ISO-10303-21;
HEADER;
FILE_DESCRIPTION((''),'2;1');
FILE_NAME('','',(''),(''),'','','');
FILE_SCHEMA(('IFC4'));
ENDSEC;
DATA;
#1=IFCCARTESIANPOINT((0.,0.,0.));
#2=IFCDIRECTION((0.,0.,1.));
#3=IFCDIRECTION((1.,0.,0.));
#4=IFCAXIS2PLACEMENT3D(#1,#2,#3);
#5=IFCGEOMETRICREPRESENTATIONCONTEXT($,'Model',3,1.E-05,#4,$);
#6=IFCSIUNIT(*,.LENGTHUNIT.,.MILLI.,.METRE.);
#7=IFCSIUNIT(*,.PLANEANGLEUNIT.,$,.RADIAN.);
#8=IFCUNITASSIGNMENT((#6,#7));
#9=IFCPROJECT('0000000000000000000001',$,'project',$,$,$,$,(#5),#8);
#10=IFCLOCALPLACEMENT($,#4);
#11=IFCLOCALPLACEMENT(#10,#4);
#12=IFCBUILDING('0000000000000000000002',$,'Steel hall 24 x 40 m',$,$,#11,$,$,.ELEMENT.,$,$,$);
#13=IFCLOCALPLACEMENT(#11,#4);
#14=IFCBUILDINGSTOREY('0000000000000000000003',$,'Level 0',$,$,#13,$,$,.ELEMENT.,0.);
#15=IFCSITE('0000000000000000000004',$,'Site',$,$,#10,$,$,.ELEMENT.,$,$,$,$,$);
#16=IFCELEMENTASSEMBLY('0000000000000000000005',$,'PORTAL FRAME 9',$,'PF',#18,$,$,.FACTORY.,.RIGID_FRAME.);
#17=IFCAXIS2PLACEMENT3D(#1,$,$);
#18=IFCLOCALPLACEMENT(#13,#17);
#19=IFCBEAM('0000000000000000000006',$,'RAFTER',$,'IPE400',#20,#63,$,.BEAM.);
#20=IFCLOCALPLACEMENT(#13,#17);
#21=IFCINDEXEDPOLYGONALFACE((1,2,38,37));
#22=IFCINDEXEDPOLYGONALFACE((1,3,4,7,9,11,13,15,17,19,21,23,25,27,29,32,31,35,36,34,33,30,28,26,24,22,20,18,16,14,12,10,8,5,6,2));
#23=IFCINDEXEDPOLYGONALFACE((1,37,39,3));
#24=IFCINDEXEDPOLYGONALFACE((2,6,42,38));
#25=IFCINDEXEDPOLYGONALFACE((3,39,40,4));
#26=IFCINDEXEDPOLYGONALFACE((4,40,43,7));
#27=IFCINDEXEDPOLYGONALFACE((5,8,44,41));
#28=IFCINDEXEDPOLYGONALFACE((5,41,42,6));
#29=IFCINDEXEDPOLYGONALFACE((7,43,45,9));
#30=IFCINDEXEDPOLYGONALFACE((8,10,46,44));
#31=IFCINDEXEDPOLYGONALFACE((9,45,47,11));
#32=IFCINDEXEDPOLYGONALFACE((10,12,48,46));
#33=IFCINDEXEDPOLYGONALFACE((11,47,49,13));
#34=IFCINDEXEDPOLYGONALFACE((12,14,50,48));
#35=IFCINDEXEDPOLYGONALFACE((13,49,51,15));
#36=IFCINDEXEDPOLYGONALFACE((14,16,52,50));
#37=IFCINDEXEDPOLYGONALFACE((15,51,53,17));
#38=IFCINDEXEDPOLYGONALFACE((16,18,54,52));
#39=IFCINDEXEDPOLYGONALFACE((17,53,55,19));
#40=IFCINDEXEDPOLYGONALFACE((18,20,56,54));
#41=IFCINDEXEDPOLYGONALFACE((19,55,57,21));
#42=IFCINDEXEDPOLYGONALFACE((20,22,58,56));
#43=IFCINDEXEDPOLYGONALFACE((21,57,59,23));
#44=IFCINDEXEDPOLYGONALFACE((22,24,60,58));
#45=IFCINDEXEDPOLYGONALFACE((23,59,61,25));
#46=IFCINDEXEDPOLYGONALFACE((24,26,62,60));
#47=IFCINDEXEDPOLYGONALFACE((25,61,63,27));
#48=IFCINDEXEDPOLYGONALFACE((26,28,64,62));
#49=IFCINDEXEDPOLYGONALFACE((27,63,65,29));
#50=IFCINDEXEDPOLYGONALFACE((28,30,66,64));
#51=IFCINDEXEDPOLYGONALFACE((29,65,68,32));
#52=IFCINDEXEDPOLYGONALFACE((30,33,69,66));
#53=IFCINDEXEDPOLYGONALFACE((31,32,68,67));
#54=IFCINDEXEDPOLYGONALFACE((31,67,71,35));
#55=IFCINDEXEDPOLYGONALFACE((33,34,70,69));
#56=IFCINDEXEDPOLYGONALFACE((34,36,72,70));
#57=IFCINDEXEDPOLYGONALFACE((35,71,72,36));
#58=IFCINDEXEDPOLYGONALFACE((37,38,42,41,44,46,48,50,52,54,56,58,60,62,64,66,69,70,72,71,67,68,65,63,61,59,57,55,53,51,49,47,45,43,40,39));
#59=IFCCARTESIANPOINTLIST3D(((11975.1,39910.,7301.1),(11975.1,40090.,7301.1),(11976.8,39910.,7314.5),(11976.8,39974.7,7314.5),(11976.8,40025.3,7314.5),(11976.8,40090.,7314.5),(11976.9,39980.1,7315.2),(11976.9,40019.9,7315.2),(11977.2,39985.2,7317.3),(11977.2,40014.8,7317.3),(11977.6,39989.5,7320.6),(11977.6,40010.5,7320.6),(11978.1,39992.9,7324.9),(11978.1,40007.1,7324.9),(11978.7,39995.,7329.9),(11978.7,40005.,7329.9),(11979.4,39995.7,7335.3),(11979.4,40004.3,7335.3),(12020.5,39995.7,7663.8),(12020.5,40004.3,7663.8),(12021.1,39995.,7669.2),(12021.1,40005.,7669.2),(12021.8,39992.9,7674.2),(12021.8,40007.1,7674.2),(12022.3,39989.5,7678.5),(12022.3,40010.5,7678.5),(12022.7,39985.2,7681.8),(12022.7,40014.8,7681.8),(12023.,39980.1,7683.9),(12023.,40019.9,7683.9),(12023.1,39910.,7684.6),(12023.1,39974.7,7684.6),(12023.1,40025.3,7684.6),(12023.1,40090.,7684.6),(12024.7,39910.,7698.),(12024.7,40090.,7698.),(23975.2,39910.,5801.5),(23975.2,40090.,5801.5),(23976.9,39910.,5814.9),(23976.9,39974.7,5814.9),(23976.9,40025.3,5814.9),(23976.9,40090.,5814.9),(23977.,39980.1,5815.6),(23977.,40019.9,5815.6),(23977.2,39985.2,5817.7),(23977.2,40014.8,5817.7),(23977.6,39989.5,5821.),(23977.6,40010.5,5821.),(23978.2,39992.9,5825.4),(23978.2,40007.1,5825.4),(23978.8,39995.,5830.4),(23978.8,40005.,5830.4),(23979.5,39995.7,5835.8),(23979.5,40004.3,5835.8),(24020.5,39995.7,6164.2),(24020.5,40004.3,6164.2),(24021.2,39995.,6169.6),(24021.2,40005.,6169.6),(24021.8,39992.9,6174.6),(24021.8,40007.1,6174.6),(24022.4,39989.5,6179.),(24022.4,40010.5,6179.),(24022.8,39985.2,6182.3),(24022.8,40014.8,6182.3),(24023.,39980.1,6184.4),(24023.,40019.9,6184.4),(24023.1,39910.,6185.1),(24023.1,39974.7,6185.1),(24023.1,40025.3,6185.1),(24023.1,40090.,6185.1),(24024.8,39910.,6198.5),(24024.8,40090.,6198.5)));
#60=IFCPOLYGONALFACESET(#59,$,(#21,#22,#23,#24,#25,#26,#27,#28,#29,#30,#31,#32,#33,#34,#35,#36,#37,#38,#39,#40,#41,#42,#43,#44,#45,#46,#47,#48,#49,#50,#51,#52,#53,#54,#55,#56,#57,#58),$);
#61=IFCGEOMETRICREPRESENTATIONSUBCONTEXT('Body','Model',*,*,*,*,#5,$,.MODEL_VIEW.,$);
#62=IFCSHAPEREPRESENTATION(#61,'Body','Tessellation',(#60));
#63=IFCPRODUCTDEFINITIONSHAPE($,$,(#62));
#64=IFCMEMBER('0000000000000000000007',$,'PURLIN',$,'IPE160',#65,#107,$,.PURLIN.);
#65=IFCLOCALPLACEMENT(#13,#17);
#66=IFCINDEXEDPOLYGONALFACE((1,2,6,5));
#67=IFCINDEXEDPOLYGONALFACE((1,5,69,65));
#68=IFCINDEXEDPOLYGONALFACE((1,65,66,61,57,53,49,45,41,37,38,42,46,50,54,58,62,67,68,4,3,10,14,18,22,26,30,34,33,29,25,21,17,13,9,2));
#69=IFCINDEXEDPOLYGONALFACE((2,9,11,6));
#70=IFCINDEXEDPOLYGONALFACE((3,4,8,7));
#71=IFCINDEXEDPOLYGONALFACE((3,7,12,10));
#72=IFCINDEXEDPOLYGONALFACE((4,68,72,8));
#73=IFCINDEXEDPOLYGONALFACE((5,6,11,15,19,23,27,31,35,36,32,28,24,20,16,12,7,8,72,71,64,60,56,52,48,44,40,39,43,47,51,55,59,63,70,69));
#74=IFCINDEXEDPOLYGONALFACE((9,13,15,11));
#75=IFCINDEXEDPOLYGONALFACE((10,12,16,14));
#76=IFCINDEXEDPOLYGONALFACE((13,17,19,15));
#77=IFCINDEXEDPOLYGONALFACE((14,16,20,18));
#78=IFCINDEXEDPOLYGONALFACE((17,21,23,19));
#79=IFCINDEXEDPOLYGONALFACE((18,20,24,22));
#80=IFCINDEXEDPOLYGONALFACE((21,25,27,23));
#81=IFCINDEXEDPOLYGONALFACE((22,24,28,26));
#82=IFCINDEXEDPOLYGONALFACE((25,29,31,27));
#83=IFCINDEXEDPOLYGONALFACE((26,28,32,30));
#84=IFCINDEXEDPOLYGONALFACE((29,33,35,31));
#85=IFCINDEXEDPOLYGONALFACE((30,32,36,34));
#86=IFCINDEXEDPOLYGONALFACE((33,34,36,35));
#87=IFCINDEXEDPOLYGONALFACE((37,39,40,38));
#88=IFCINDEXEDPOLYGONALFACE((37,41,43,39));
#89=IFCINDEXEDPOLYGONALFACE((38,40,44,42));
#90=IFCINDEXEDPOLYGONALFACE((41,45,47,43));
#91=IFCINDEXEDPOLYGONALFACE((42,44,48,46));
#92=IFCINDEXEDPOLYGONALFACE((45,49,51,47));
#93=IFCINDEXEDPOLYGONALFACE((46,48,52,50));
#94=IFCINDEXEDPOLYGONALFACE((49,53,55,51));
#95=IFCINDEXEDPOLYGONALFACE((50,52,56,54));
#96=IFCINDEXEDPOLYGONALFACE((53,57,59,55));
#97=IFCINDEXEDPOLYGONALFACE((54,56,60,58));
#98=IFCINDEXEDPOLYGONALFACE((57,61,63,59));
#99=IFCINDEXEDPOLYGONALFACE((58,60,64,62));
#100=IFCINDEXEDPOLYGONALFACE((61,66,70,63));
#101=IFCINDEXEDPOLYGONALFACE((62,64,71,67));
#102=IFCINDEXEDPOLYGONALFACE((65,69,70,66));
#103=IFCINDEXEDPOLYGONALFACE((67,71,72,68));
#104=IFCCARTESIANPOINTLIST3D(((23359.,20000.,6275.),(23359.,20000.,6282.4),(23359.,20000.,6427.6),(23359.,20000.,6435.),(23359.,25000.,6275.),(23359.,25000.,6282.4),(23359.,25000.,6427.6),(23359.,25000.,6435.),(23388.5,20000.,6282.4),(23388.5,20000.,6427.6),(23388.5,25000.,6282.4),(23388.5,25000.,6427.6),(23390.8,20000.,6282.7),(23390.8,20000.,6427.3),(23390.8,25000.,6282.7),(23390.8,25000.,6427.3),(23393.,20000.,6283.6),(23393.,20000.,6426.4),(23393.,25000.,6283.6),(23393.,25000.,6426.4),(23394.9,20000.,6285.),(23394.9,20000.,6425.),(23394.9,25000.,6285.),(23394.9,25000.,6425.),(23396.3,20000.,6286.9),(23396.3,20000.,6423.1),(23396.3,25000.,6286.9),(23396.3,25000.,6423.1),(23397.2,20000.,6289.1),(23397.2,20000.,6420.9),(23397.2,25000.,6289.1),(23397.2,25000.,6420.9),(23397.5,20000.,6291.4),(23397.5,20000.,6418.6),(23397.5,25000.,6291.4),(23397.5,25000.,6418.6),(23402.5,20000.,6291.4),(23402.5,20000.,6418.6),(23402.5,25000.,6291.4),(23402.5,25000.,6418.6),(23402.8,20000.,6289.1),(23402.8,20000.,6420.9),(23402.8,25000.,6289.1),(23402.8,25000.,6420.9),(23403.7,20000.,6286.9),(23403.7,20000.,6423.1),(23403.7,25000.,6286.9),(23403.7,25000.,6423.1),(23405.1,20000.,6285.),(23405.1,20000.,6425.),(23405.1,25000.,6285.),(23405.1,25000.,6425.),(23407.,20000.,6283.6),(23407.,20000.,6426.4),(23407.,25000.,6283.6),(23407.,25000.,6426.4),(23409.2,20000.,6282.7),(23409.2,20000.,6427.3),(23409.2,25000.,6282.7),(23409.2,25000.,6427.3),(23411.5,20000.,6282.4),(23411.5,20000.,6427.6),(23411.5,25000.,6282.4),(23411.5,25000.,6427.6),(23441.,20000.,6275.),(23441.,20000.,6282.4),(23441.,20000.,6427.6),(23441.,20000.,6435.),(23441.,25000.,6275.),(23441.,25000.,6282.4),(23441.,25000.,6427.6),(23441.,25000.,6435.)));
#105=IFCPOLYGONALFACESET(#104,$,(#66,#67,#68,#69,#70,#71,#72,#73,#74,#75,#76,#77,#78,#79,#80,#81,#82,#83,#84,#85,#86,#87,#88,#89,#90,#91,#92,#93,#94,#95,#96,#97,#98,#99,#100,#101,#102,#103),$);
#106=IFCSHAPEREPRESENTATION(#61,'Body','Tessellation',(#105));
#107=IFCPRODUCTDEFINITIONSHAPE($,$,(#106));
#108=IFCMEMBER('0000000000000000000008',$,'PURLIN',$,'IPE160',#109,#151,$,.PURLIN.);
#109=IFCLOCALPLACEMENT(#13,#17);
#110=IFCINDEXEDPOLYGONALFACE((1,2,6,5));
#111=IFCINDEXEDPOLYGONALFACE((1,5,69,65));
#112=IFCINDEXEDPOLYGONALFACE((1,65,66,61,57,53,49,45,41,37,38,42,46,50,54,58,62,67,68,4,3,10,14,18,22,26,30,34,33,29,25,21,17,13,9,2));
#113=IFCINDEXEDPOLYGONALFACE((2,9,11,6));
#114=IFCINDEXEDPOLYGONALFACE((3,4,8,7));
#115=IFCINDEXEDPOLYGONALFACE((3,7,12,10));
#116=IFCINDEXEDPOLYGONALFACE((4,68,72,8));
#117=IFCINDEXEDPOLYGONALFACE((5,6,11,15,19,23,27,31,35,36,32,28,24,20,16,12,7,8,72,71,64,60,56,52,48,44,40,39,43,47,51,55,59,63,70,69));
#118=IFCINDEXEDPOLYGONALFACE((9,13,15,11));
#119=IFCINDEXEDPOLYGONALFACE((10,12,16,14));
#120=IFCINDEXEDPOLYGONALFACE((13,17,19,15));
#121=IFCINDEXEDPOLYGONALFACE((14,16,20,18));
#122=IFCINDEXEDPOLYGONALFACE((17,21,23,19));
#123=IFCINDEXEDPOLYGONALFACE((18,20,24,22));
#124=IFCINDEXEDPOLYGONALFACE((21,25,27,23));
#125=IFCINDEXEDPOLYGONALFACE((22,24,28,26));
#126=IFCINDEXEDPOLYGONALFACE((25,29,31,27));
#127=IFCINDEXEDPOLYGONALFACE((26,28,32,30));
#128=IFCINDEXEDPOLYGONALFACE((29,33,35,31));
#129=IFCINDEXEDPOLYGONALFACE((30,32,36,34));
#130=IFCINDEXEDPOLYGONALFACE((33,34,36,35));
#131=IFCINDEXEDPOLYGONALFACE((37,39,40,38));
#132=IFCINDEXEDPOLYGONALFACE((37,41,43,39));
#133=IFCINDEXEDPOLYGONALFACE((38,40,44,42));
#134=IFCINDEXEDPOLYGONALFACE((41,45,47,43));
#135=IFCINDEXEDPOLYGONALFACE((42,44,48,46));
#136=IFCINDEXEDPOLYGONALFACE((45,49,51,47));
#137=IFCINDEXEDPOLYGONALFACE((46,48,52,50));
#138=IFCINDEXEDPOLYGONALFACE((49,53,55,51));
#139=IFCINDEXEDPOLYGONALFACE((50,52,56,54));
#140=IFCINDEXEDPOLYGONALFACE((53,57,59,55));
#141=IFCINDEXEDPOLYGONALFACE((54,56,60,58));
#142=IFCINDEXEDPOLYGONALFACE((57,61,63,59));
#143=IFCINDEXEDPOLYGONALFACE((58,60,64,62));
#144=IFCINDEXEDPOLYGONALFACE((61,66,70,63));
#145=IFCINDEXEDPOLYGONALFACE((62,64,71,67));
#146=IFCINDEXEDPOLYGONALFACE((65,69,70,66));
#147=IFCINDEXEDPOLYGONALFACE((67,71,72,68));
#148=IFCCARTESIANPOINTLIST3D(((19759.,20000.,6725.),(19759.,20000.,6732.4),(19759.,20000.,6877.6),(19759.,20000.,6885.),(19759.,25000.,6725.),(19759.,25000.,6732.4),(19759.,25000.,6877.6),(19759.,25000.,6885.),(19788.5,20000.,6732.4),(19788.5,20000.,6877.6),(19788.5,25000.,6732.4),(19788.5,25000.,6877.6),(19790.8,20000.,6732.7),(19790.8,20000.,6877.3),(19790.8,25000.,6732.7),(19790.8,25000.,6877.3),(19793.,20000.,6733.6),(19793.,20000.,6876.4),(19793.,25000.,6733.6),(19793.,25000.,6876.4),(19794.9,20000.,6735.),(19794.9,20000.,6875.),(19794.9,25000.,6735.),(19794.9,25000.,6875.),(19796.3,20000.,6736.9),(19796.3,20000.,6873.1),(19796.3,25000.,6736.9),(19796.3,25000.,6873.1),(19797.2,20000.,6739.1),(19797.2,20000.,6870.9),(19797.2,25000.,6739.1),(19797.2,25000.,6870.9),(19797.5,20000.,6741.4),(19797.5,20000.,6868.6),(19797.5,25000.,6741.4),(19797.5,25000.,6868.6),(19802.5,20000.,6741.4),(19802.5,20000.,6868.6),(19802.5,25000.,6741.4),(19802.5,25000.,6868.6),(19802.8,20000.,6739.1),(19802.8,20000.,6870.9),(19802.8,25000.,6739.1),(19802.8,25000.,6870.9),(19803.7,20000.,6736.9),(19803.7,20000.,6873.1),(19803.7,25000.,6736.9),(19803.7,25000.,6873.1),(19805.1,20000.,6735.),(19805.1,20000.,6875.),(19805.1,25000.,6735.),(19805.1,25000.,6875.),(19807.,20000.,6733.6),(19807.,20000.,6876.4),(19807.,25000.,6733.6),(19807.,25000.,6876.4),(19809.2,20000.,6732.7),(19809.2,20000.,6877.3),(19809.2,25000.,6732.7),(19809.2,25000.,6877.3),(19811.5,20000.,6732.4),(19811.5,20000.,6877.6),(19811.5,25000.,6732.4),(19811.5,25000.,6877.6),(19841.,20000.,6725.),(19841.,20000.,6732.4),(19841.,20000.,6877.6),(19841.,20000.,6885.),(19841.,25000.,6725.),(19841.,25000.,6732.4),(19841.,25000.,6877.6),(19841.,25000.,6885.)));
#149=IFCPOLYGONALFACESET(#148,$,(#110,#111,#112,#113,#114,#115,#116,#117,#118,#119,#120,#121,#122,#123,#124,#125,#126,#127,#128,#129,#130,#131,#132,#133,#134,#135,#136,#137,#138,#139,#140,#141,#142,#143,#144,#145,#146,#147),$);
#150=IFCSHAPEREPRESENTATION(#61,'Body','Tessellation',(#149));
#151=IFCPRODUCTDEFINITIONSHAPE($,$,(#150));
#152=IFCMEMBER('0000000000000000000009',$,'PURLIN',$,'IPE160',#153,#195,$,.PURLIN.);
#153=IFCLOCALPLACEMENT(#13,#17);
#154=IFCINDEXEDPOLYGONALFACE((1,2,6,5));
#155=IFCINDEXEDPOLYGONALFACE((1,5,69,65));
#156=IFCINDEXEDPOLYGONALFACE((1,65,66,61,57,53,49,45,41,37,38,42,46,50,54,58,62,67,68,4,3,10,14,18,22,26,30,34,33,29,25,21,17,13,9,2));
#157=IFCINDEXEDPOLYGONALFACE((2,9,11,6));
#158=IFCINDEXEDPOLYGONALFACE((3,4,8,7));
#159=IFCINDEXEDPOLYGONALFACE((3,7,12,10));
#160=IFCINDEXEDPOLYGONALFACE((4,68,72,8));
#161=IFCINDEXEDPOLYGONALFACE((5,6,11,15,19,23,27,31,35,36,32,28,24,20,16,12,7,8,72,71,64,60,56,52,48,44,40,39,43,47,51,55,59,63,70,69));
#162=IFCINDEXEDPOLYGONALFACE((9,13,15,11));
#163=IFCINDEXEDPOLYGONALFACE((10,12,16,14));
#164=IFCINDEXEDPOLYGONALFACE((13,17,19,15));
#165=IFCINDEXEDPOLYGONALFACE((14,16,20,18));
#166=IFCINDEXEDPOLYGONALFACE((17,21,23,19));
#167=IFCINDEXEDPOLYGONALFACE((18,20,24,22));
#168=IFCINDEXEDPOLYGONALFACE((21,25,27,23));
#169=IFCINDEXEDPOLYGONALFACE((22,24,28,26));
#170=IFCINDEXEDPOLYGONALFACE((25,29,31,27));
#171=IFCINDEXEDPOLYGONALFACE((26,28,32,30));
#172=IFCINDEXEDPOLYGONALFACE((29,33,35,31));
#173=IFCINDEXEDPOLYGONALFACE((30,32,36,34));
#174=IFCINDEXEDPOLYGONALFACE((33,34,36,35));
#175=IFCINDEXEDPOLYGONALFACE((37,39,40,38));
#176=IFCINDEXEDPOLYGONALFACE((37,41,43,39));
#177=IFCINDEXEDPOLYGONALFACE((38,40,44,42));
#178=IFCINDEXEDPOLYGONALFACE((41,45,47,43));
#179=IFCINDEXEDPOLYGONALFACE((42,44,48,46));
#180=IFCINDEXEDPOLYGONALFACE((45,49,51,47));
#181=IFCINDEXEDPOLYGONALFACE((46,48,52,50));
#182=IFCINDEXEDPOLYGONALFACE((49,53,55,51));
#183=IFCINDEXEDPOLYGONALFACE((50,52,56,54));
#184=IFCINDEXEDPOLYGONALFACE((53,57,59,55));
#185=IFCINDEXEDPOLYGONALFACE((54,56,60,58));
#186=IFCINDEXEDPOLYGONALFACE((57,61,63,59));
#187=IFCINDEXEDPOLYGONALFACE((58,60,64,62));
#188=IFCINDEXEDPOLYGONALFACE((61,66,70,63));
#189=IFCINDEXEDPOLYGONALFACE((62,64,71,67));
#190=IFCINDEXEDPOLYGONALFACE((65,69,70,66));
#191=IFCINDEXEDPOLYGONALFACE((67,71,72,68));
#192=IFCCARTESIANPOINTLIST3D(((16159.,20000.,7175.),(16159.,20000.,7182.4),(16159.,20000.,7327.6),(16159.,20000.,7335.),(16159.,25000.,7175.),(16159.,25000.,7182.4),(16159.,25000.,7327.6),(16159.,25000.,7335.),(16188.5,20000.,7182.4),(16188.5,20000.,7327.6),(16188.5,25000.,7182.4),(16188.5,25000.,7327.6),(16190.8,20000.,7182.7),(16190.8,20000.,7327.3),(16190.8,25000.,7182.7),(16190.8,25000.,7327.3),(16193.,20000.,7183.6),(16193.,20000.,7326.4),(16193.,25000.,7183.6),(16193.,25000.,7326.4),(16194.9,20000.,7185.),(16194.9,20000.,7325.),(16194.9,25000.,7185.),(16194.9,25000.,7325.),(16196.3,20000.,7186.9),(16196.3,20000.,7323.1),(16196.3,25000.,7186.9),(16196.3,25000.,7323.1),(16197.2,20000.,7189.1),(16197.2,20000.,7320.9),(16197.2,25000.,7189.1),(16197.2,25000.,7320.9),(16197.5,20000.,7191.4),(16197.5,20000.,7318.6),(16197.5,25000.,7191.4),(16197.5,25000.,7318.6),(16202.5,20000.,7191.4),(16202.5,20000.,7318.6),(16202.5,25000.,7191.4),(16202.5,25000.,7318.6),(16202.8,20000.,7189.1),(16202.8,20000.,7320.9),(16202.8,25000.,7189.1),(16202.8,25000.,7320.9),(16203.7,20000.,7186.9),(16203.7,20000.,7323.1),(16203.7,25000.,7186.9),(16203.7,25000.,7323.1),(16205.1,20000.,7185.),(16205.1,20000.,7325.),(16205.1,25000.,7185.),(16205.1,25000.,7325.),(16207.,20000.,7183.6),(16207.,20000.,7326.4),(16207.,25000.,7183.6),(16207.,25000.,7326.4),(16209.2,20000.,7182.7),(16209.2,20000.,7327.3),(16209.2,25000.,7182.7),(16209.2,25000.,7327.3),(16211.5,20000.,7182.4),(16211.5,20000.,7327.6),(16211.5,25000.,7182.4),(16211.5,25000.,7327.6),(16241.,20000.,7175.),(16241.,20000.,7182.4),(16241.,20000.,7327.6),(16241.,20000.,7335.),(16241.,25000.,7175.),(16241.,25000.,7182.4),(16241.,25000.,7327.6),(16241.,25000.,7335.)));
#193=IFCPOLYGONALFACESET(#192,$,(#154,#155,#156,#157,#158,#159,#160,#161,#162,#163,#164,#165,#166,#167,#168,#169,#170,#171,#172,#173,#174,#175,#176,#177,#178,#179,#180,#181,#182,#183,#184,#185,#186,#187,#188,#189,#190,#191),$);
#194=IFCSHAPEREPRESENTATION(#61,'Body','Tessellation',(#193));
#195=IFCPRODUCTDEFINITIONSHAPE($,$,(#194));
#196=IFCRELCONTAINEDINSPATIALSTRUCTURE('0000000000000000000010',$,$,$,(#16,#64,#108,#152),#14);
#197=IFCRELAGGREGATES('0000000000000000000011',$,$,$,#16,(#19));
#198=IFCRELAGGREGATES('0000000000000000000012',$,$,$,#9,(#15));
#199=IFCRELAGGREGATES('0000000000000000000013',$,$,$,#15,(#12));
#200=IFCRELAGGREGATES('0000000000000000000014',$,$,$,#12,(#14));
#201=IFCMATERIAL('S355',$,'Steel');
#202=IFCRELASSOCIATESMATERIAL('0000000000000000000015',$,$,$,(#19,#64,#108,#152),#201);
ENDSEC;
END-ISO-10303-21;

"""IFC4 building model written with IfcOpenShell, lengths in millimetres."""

from ifc_helpers import new_model, si_unit, frame, origin_with_axes, place, context, subcontext, project, spatial, i_section, extrude, material, element, aggregate, save


model = new_model("IFC4")

# Units and contexts
model_context = context("Model", 3, precision=1e-05, world=origin_with_axes())
body_context = subcontext(model_context, "Body", "Model", "MODEL_VIEW")
ifc_project = project(units=[si_unit("LENGTHUNIT", "METRE", prefix="MILLI"), si_unit("PLANEANGLEUNIT", "RADIAN")], contexts=[model_context])

# Site, building, storey
site_placement = place(None, origin_with_axes())
site = spatial("IfcSite", under=ifc_project, at=site_placement, Name="Site", CompositionType="ELEMENT")
building_placement = place(site_placement, origin_with_axes())
building = spatial("IfcBuilding", under=site, at=building_placement, Name="Steel hall 24 x 40 m", CompositionType="ELEMENT")
storey_placement = place(building_placement, origin_with_axes())
storey = spatial("IfcBuildingStorey", under=building, at=storey_placement, Name="Level 0", CompositionType="ELEMENT", Elevation=0.0)

# Element assembly
ifc_material = material(Name="S355", Category="Steel")
assembly_1_placement = place(storey_placement, frame((0.0, 40000.0, 0.0), z_axis=(0.0, 0.0, 1.0), x_axis=(1.0, 0.0, 0.0)))
assembly_1 = element("IfcElementAssembly", 1, at=assembly_1_placement, inside=storey, Name="PORTAL FRAME 9", ObjectType="PF", AssemblyPlace="FACTORY", PredefinedType="RIGID_FRAME")

# Beam
beam_1_placement = place(storey_placement, frame((24000.0, 40000.0, 6000.0), z_axis=(-0.9923, 0.0, 0.124), x_axis=(0.0, 1.0, 0.0)))
beam_1 = element("IfcBeam", 2, at=beam_1_placement, material=ifc_material, Name="RAFTER", ObjectType="IPE400", PredefinedType="BEAM", context=body_context, shape_type="SweptSolid", body=[
    extrude(i_section(OverallWidth=180.0, OverallDepth=400.0, WebThickness=8.6, FlangeThickness=13.5, FilletRadius=21.0), origin_with_axes(), (0.0, 0.0, 1.0), 12093.4),
])

# Members
for number, where, z_axis, x_axis, name in (
    (3, (23400.0, 20000.0, 6355.0), (0.0, 1.0, 0.0), (1.0, 0.0, 0.0), "PURLIN"),
    (4, (19800.0, 20000.0, 6805.0), (0.0, 1.0, 0.0), (1.0, 0.0, 0.0), "PURLIN"),
    (5, (16200.0, 20000.0, 7255.0), (0.0, 1.0, 0.0), (1.0, 0.0, 0.0), "PURLIN"),
):
    element("IfcMember", number, at=place(storey_placement, frame(where, z_axis=z_axis, x_axis=x_axis)), inside=storey, material=ifc_material, Name=name, ObjectType="IPE160", PredefinedType="PURLIN", context=body_context, shape_type="SweptSolid", body=[
        extrude(i_section(OverallWidth=82.0, OverallDepth=160.0, WebThickness=5.0, FlangeThickness=7.4, FilletRadius=9.0), origin_with_axes(), (0.0, 0.0, 1.0), 5000.0),
    ])

aggregate(assembly_1, [beam_1])

save(model, "model.ifc")
